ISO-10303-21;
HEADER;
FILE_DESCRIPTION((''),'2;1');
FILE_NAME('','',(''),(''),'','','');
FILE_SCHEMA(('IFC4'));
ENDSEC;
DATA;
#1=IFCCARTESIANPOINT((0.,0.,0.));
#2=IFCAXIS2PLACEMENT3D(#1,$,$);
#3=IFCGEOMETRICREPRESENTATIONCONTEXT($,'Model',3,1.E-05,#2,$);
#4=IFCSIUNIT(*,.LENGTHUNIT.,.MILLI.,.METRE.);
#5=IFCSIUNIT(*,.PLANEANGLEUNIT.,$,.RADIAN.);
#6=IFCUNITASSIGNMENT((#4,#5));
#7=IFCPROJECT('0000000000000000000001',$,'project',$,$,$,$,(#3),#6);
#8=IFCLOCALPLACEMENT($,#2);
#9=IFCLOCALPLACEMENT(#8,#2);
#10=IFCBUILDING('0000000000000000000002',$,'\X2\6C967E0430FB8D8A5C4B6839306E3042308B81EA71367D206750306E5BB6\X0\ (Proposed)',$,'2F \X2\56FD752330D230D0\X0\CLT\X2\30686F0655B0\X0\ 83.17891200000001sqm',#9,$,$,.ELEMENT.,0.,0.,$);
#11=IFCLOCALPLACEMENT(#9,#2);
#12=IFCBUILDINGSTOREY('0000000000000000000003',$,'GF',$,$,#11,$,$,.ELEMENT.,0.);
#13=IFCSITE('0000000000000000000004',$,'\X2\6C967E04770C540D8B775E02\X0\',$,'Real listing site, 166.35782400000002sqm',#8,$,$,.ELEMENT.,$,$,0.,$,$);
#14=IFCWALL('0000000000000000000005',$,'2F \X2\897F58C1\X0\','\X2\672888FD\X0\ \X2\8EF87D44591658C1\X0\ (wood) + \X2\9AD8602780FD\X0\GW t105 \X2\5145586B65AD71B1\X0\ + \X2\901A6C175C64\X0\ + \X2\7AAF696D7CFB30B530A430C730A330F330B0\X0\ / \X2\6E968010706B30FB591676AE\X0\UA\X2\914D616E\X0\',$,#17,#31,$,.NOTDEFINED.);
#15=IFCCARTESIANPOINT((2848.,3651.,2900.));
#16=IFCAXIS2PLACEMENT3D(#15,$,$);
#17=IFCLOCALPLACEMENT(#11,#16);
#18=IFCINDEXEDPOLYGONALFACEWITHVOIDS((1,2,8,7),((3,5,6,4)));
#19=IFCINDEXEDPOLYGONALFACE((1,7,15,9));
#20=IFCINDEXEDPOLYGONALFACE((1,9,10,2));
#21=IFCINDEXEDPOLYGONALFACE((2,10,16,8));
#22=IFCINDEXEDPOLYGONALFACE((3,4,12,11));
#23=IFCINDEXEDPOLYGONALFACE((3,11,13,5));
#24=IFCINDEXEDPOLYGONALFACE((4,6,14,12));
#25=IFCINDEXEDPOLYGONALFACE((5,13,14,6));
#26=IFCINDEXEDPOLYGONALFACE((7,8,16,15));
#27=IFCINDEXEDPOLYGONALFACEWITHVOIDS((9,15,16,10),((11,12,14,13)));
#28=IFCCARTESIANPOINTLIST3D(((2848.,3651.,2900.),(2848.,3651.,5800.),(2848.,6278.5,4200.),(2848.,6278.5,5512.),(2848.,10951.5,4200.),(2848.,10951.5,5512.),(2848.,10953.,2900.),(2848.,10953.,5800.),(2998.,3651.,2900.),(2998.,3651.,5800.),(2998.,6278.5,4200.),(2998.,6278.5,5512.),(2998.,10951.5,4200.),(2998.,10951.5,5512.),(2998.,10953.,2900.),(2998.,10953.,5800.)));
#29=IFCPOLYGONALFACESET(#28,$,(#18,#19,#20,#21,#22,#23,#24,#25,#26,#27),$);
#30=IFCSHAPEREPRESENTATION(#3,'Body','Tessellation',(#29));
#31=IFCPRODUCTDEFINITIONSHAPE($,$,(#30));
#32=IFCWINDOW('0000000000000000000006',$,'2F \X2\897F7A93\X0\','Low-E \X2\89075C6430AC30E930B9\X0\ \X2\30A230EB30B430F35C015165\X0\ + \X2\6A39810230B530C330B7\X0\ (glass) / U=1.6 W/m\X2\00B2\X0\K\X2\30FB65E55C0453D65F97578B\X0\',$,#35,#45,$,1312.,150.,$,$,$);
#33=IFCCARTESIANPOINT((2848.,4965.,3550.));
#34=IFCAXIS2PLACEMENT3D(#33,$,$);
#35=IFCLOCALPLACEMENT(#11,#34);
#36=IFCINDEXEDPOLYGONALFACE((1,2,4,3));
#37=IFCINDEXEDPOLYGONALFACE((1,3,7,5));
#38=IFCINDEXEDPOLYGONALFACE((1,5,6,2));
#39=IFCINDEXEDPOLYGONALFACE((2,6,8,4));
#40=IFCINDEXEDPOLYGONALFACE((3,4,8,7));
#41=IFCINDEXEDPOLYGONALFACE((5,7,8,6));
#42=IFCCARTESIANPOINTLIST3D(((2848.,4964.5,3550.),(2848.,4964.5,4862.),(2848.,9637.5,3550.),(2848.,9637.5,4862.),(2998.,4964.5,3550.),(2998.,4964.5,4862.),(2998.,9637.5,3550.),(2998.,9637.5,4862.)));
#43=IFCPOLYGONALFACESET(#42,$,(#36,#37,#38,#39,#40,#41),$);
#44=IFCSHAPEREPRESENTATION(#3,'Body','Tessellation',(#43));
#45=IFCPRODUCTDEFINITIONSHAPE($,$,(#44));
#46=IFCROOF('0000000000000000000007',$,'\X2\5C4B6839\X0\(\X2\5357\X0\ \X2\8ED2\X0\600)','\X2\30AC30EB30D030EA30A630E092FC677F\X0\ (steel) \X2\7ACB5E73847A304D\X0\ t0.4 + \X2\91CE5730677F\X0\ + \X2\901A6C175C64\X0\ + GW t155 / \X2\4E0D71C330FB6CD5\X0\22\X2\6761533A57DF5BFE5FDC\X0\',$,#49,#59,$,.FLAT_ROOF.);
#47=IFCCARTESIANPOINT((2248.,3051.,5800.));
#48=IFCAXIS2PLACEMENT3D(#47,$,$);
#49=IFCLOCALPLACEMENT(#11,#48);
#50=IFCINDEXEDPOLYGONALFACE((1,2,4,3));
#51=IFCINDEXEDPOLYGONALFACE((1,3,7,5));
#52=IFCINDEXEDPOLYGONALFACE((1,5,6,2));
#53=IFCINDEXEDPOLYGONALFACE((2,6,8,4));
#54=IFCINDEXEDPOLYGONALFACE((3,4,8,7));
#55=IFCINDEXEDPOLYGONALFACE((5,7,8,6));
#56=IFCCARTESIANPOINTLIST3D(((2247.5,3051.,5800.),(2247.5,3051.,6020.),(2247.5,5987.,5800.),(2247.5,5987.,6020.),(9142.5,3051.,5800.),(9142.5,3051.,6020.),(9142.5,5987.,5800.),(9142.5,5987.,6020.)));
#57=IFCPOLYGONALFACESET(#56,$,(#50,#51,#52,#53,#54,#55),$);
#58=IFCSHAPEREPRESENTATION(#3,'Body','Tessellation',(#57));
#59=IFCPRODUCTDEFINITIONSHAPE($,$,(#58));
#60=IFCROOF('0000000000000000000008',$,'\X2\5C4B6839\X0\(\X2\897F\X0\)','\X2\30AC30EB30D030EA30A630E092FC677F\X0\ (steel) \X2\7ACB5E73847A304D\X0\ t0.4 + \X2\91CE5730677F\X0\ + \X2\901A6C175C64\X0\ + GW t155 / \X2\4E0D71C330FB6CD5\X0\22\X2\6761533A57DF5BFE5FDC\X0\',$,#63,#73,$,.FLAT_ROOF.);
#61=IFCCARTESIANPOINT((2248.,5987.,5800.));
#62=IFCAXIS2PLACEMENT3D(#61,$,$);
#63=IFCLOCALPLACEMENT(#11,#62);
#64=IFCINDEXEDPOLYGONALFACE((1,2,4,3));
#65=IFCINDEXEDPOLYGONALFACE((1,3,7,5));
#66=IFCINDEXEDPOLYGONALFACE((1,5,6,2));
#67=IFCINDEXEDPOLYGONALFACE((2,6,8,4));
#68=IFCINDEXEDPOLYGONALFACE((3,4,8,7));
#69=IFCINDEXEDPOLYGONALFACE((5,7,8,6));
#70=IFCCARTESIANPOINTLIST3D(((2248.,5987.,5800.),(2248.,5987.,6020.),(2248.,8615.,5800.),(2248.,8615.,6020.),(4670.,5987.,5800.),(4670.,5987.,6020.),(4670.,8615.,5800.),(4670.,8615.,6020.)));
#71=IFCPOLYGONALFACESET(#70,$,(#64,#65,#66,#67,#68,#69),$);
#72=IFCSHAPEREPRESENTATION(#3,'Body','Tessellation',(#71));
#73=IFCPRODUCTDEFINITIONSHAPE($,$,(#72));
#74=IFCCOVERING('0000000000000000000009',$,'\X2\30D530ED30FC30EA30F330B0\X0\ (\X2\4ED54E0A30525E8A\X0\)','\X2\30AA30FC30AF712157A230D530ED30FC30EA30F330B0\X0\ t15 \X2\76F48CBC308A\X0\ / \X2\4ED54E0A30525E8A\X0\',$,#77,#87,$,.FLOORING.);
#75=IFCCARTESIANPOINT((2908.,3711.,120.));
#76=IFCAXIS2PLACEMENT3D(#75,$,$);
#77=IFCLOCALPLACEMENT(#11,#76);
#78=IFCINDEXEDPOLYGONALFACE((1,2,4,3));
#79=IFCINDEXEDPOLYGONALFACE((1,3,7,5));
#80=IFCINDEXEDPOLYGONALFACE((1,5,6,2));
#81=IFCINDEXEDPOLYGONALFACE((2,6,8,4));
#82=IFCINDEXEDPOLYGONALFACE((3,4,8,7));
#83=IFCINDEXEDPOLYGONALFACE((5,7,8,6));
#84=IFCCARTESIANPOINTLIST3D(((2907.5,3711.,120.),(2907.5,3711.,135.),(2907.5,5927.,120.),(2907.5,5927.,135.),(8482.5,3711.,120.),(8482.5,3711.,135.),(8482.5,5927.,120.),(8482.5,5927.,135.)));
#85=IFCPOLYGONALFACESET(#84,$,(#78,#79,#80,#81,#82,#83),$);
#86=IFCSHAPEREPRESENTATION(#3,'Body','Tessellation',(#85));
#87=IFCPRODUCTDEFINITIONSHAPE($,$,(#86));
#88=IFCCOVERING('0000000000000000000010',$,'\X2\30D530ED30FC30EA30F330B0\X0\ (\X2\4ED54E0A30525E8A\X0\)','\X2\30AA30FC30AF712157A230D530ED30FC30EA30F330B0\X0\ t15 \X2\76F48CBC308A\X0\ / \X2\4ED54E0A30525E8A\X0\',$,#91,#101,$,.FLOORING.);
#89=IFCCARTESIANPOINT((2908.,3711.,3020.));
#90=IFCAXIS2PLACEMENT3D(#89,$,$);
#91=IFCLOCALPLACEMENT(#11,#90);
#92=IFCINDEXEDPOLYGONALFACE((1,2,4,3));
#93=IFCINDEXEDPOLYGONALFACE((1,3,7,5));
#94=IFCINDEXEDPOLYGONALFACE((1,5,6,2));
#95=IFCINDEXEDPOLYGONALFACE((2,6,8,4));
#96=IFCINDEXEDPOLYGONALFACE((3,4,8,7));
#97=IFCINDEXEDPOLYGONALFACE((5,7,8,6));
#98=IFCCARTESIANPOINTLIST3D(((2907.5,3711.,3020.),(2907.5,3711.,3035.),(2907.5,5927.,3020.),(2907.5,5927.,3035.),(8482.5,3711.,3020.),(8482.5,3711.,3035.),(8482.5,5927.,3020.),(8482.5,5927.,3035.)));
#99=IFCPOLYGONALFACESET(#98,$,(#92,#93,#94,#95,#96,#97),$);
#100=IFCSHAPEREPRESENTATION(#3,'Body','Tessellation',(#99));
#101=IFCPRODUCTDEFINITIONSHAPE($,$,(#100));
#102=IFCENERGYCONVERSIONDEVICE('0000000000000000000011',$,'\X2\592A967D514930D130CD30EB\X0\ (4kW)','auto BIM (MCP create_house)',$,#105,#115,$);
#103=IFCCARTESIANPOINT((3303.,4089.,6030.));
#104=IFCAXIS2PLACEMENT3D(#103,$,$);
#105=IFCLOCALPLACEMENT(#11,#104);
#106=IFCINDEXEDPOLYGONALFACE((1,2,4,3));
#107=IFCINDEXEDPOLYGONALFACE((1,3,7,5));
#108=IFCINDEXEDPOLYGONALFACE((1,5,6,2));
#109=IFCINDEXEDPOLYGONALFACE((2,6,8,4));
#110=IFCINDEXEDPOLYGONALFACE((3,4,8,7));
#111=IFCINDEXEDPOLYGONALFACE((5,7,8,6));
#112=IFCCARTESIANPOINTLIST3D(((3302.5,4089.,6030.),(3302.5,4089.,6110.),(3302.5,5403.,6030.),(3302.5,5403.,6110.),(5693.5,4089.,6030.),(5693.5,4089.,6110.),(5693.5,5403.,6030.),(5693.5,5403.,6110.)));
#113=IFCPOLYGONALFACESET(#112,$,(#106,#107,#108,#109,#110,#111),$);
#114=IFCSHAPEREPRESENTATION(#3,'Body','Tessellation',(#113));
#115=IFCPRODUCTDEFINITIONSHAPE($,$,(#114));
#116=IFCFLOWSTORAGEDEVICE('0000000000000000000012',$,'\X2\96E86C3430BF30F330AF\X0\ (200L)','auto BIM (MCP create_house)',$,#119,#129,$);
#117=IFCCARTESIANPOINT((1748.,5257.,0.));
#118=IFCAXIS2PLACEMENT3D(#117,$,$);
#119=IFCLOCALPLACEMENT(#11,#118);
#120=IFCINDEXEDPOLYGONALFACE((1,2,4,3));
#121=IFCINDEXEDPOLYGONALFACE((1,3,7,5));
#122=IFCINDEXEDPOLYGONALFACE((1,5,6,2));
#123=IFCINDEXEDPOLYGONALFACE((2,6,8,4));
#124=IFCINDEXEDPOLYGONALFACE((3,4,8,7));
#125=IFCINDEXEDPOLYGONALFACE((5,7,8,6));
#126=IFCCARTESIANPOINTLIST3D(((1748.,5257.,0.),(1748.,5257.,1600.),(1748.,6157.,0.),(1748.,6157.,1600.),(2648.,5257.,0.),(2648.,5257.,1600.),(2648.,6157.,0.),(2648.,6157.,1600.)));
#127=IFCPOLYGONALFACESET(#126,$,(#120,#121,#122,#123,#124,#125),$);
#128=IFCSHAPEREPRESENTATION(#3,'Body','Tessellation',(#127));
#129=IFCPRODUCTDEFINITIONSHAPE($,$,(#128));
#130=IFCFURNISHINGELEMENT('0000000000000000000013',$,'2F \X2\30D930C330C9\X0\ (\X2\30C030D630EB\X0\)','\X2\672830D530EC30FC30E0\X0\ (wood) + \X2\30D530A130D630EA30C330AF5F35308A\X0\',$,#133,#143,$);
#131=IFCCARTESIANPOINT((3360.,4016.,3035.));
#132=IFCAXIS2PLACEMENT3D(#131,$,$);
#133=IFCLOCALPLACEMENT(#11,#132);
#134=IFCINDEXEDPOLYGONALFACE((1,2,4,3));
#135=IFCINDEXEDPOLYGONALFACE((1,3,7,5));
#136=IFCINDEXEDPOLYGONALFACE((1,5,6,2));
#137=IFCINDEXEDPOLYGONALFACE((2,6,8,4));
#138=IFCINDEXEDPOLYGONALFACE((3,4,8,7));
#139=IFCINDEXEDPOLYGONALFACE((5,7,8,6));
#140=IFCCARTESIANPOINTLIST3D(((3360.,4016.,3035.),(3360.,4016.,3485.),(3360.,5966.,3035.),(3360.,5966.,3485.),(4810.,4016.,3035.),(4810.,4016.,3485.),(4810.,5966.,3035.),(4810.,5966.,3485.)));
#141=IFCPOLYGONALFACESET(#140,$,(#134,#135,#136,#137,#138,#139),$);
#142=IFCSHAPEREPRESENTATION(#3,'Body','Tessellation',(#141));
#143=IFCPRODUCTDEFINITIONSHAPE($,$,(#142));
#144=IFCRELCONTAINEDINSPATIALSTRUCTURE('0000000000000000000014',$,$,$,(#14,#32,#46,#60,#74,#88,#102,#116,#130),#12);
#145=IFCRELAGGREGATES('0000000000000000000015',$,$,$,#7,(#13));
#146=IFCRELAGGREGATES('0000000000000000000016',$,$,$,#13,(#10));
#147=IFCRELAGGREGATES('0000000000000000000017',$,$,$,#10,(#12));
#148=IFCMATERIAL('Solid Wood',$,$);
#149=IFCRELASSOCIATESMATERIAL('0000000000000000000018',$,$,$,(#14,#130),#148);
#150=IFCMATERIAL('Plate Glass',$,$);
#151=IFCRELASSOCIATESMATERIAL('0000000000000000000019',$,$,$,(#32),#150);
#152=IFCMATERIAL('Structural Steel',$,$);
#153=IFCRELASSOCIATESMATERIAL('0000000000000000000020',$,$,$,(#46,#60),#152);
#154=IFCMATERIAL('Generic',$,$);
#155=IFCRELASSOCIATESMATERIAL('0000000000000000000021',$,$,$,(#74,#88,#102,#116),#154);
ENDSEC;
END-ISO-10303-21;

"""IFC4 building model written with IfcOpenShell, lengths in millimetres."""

from ifc_helpers import new_model, si_unit, frame, frame_2d, origin, place, context, project, spatial, rectangle, extrude, material, element, fill, save


model = new_model("IFC4")

# Units and contexts
model_context = context("Model", 3, precision=1e-05, world=origin())
ifc_project = project(units=[si_unit("LENGTHUNIT", "METRE", prefix="MILLI"), si_unit("PLANEANGLEUNIT", "RADIAN")], contexts=[model_context])

# Site, building, storey
site_placement = place(None, origin())
site = spatial("IfcSite", under=ifc_project, at=site_placement, Name="沖縄県名護市", ObjectType="Real listing site, 166.35782400000002sqm", CompositionType="ELEMENT", RefElevation=0.0)
building_placement = place(site_placement, origin())
building = spatial("IfcBuilding", under=site, at=building_placement, Name="沖縄・越屋根のある自然素材の家 (Proposed)", ObjectType="2F 国産ヒバCLTと漆喰 83.17891200000001sqm", CompositionType="ELEMENT", ElevationOfRefHeight=0.0, ElevationOfTerrain=0.0)
storey_placement = place(building_placement, origin())
storey = spatial("IfcBuildingStorey", under=building, at=storey_placement, Name="GF", CompositionType="ELEMENT", Elevation=0.0)

# Shared definitions
ifc_material_1 = material(Name="Solid Wood")

# Shared definitions
ifc_material_2 = material(Name="Plate Glass")

# Wall, opening, window
wall_1_placement = place(storey_placement, frame((2848.0, 3651.0, 2900.0)))
wall_1 = element("IfcWall", 1, at=wall_1_placement, inside=storey, material=ifc_material_1, Name="2F 西壁", Description="木製 軸組外壁 (wood) + 高性能GW t105 充填断熱 + 通気層 + 窯業系サイディング / 準耐火・外皮UA配慮", PredefinedType="NOTDEFINED", context=model_context, shape_type="SweptSolid", body=[
    extrude(rectangle(XDim=150.0, YDim=7302.0, at=frame_2d((75.0, 3651.0))), frame((2848.0, 3651.0, 2900.0)), (0.0, 0.0, 1.0), 2900.0),
])
opening_1_placement = place(storey_placement, frame((2848.0, 4965.0, 3550.0)))
opening_1 = element("IfcOpeningElement", 2, at=opening_1_placement, cuts=wall_1, PredefinedType="NOTDEFINED", context=model_context, shape_type="SweptSolid", body=[
    extrude(rectangle(XDim=150.0, YDim=4673.0, at=frame_2d((75.0, 2336.0))), frame((2848.0, 4965.0, 3550.0)), (0.0, 0.0, 1.0), 1312.0),
])
window_1_placement = place(storey_placement, frame((2848.0, 4965.0, 3550.0)))
window_1 = element("IfcWindow", 3, at=window_1_placement, inside=storey, material=ifc_material_2, Name="2F 西窓", Description="Low-E 複層ガラス アルゴン封入 + 樹脂サッシ (glass) / U=1.6 W/m²K・日射取得型", OverallHeight=1312.0, OverallWidth=150.0, context=model_context, shape_type="SweptSolid", body=[
    extrude(rectangle(XDim=150.0, YDim=4673.0, at=frame_2d((75.0, 2336.0))), frame((2848.0, 4965.0, 3550.0)), (0.0, 0.0, 1.0), 1312.0),
])
fill(opening_1, window_1)

# Roofs
ifc_material_3 = material(Name="Structural Steel")
roof_1_placement = place(storey_placement, frame((2248.0, 3051.0, 5800.0)))
element("IfcRoof", 4, at=roof_1_placement, inside=storey, material=ifc_material_3, Name="屋根(南 軒600)", Description="ガルバリウム鋼板 (steel) 立平葺き t0.4 + 野地板 + 通気層 + GW t155 / 不燃・法22条区域対応", PredefinedType="FLAT_ROOF", context=model_context, shape_type="SweptSolid", body=[
    extrude(rectangle(XDim=6895.0, YDim=2936.0, at=frame_2d((3447.0, 1468.0))), frame((2248.0, 3051.0, 5800.0)), (0.0, 0.0, 1.0), 220.0),
])
roof_2_placement = place(storey_placement, frame((2248.0, 5987.0, 5800.0)))
element("IfcRoof", 5, at=roof_2_placement, inside=storey, material=ifc_material_3, Name="屋根(西)", Description="ガルバリウム鋼板 (steel) 立平葺き t0.4 + 野地板 + 通気層 + GW t155 / 不燃・法22条区域対応", PredefinedType="FLAT_ROOF", context=model_context, shape_type="SweptSolid", body=[
    extrude(rectangle(XDim=2422.0, YDim=2628.0, at=frame_2d((1211.0, 1314.0))), frame((2248.0, 5987.0, 5800.0)), (0.0, 0.0, 1.0), 220.0),
])

# Coverings
ifc_material_4 = material(Name="Generic")
covering_1_placement = place(storey_placement, frame((2908.0, 3711.0, 120.0)))
element("IfcCovering", 6, at=covering_1_placement, inside=storey, material=ifc_material_4, Name="フローリング (仕上げ床)", Description="オーク無垢フローリング t15 直貼り / 仕上げ床", PredefinedType="FLOORING", context=model_context, shape_type="SweptSolid", body=[
    extrude(rectangle(XDim=5575.0, YDim=2216.0, at=frame_2d((2787.0, 1108.0))), frame((2908.0, 3711.0, 120.0)), (0.0, 0.0, 1.0), 15.0),
])
covering_2_placement = place(storey_placement, frame((2908.0, 3711.0, 3020.0)))
element("IfcCovering", 7, at=covering_2_placement, inside=storey, material=ifc_material_4, Name="フローリング (仕上げ床)", Description="オーク無垢フローリング t15 直貼り / 仕上げ床", PredefinedType="FLOORING", context=model_context, shape_type="SweptSolid", body=[
    extrude(rectangle(XDim=5575.0, YDim=2216.0, at=frame_2d((2787.0, 1108.0))), frame((2908.0, 3711.0, 3020.0)), (0.0, 0.0, 1.0), 15.0),
])

# Energy conversion device
energy_conversion_device_placement = place(storey_placement, frame((3303.0, 4089.0, 6030.0)))
element("IfcEnergyConversionDevice", 8, at=energy_conversion_device_placement, inside=storey, material=ifc_material_4, Name="太陽光パネル (4kW)", Description="auto BIM (MCP create_house)", context=model_context, shape_type="SweptSolid", body=[
    extrude(rectangle(XDim=2391.0, YDim=1314.0, at=frame_2d((1195.0, 657.0))), frame((3303.0, 4089.0, 6030.0)), (0.0, 0.0, 1.0), 80.0),
])

# Flow storage device
flow_storage_device_placement = place(storey_placement, frame((1748.0, 5257.0, 0.0)))
element("IfcFlowStorageDevice", 9, at=flow_storage_device_placement, inside=storey, material=ifc_material_4, Name="雨水タンク (200L)", Description="auto BIM (MCP create_house)", context=model_context, shape_type="SweptSolid", body=[
    extrude(rectangle(XDim=900.0, YDim=900.0, at=frame_2d((450.0, 450.0))), frame((1748.0, 5257.0, 0.0)), (0.0, 0.0, 1.0), 1600.0),
])

# Furnishing element
furnishing_placement = place(storey_placement, frame((3360.0, 4016.0, 3035.0)))
element("IfcFurnishingElement", 10, at=furnishing_placement, inside=storey, material=ifc_material_1, Name="2F ベッド (ダブル)", Description="木フレーム (wood) + ファブリック張り", context=model_context, shape_type="SweptSolid", body=[
    extrude(rectangle(XDim=1450.0, YDim=1950.0, at=frame_2d((725.0, 975.0))), frame((3360.0, 4016.0, 3035.0)), (0.0, 0.0, 1.0), 450.0),
])

save(model, "model.ifc")
